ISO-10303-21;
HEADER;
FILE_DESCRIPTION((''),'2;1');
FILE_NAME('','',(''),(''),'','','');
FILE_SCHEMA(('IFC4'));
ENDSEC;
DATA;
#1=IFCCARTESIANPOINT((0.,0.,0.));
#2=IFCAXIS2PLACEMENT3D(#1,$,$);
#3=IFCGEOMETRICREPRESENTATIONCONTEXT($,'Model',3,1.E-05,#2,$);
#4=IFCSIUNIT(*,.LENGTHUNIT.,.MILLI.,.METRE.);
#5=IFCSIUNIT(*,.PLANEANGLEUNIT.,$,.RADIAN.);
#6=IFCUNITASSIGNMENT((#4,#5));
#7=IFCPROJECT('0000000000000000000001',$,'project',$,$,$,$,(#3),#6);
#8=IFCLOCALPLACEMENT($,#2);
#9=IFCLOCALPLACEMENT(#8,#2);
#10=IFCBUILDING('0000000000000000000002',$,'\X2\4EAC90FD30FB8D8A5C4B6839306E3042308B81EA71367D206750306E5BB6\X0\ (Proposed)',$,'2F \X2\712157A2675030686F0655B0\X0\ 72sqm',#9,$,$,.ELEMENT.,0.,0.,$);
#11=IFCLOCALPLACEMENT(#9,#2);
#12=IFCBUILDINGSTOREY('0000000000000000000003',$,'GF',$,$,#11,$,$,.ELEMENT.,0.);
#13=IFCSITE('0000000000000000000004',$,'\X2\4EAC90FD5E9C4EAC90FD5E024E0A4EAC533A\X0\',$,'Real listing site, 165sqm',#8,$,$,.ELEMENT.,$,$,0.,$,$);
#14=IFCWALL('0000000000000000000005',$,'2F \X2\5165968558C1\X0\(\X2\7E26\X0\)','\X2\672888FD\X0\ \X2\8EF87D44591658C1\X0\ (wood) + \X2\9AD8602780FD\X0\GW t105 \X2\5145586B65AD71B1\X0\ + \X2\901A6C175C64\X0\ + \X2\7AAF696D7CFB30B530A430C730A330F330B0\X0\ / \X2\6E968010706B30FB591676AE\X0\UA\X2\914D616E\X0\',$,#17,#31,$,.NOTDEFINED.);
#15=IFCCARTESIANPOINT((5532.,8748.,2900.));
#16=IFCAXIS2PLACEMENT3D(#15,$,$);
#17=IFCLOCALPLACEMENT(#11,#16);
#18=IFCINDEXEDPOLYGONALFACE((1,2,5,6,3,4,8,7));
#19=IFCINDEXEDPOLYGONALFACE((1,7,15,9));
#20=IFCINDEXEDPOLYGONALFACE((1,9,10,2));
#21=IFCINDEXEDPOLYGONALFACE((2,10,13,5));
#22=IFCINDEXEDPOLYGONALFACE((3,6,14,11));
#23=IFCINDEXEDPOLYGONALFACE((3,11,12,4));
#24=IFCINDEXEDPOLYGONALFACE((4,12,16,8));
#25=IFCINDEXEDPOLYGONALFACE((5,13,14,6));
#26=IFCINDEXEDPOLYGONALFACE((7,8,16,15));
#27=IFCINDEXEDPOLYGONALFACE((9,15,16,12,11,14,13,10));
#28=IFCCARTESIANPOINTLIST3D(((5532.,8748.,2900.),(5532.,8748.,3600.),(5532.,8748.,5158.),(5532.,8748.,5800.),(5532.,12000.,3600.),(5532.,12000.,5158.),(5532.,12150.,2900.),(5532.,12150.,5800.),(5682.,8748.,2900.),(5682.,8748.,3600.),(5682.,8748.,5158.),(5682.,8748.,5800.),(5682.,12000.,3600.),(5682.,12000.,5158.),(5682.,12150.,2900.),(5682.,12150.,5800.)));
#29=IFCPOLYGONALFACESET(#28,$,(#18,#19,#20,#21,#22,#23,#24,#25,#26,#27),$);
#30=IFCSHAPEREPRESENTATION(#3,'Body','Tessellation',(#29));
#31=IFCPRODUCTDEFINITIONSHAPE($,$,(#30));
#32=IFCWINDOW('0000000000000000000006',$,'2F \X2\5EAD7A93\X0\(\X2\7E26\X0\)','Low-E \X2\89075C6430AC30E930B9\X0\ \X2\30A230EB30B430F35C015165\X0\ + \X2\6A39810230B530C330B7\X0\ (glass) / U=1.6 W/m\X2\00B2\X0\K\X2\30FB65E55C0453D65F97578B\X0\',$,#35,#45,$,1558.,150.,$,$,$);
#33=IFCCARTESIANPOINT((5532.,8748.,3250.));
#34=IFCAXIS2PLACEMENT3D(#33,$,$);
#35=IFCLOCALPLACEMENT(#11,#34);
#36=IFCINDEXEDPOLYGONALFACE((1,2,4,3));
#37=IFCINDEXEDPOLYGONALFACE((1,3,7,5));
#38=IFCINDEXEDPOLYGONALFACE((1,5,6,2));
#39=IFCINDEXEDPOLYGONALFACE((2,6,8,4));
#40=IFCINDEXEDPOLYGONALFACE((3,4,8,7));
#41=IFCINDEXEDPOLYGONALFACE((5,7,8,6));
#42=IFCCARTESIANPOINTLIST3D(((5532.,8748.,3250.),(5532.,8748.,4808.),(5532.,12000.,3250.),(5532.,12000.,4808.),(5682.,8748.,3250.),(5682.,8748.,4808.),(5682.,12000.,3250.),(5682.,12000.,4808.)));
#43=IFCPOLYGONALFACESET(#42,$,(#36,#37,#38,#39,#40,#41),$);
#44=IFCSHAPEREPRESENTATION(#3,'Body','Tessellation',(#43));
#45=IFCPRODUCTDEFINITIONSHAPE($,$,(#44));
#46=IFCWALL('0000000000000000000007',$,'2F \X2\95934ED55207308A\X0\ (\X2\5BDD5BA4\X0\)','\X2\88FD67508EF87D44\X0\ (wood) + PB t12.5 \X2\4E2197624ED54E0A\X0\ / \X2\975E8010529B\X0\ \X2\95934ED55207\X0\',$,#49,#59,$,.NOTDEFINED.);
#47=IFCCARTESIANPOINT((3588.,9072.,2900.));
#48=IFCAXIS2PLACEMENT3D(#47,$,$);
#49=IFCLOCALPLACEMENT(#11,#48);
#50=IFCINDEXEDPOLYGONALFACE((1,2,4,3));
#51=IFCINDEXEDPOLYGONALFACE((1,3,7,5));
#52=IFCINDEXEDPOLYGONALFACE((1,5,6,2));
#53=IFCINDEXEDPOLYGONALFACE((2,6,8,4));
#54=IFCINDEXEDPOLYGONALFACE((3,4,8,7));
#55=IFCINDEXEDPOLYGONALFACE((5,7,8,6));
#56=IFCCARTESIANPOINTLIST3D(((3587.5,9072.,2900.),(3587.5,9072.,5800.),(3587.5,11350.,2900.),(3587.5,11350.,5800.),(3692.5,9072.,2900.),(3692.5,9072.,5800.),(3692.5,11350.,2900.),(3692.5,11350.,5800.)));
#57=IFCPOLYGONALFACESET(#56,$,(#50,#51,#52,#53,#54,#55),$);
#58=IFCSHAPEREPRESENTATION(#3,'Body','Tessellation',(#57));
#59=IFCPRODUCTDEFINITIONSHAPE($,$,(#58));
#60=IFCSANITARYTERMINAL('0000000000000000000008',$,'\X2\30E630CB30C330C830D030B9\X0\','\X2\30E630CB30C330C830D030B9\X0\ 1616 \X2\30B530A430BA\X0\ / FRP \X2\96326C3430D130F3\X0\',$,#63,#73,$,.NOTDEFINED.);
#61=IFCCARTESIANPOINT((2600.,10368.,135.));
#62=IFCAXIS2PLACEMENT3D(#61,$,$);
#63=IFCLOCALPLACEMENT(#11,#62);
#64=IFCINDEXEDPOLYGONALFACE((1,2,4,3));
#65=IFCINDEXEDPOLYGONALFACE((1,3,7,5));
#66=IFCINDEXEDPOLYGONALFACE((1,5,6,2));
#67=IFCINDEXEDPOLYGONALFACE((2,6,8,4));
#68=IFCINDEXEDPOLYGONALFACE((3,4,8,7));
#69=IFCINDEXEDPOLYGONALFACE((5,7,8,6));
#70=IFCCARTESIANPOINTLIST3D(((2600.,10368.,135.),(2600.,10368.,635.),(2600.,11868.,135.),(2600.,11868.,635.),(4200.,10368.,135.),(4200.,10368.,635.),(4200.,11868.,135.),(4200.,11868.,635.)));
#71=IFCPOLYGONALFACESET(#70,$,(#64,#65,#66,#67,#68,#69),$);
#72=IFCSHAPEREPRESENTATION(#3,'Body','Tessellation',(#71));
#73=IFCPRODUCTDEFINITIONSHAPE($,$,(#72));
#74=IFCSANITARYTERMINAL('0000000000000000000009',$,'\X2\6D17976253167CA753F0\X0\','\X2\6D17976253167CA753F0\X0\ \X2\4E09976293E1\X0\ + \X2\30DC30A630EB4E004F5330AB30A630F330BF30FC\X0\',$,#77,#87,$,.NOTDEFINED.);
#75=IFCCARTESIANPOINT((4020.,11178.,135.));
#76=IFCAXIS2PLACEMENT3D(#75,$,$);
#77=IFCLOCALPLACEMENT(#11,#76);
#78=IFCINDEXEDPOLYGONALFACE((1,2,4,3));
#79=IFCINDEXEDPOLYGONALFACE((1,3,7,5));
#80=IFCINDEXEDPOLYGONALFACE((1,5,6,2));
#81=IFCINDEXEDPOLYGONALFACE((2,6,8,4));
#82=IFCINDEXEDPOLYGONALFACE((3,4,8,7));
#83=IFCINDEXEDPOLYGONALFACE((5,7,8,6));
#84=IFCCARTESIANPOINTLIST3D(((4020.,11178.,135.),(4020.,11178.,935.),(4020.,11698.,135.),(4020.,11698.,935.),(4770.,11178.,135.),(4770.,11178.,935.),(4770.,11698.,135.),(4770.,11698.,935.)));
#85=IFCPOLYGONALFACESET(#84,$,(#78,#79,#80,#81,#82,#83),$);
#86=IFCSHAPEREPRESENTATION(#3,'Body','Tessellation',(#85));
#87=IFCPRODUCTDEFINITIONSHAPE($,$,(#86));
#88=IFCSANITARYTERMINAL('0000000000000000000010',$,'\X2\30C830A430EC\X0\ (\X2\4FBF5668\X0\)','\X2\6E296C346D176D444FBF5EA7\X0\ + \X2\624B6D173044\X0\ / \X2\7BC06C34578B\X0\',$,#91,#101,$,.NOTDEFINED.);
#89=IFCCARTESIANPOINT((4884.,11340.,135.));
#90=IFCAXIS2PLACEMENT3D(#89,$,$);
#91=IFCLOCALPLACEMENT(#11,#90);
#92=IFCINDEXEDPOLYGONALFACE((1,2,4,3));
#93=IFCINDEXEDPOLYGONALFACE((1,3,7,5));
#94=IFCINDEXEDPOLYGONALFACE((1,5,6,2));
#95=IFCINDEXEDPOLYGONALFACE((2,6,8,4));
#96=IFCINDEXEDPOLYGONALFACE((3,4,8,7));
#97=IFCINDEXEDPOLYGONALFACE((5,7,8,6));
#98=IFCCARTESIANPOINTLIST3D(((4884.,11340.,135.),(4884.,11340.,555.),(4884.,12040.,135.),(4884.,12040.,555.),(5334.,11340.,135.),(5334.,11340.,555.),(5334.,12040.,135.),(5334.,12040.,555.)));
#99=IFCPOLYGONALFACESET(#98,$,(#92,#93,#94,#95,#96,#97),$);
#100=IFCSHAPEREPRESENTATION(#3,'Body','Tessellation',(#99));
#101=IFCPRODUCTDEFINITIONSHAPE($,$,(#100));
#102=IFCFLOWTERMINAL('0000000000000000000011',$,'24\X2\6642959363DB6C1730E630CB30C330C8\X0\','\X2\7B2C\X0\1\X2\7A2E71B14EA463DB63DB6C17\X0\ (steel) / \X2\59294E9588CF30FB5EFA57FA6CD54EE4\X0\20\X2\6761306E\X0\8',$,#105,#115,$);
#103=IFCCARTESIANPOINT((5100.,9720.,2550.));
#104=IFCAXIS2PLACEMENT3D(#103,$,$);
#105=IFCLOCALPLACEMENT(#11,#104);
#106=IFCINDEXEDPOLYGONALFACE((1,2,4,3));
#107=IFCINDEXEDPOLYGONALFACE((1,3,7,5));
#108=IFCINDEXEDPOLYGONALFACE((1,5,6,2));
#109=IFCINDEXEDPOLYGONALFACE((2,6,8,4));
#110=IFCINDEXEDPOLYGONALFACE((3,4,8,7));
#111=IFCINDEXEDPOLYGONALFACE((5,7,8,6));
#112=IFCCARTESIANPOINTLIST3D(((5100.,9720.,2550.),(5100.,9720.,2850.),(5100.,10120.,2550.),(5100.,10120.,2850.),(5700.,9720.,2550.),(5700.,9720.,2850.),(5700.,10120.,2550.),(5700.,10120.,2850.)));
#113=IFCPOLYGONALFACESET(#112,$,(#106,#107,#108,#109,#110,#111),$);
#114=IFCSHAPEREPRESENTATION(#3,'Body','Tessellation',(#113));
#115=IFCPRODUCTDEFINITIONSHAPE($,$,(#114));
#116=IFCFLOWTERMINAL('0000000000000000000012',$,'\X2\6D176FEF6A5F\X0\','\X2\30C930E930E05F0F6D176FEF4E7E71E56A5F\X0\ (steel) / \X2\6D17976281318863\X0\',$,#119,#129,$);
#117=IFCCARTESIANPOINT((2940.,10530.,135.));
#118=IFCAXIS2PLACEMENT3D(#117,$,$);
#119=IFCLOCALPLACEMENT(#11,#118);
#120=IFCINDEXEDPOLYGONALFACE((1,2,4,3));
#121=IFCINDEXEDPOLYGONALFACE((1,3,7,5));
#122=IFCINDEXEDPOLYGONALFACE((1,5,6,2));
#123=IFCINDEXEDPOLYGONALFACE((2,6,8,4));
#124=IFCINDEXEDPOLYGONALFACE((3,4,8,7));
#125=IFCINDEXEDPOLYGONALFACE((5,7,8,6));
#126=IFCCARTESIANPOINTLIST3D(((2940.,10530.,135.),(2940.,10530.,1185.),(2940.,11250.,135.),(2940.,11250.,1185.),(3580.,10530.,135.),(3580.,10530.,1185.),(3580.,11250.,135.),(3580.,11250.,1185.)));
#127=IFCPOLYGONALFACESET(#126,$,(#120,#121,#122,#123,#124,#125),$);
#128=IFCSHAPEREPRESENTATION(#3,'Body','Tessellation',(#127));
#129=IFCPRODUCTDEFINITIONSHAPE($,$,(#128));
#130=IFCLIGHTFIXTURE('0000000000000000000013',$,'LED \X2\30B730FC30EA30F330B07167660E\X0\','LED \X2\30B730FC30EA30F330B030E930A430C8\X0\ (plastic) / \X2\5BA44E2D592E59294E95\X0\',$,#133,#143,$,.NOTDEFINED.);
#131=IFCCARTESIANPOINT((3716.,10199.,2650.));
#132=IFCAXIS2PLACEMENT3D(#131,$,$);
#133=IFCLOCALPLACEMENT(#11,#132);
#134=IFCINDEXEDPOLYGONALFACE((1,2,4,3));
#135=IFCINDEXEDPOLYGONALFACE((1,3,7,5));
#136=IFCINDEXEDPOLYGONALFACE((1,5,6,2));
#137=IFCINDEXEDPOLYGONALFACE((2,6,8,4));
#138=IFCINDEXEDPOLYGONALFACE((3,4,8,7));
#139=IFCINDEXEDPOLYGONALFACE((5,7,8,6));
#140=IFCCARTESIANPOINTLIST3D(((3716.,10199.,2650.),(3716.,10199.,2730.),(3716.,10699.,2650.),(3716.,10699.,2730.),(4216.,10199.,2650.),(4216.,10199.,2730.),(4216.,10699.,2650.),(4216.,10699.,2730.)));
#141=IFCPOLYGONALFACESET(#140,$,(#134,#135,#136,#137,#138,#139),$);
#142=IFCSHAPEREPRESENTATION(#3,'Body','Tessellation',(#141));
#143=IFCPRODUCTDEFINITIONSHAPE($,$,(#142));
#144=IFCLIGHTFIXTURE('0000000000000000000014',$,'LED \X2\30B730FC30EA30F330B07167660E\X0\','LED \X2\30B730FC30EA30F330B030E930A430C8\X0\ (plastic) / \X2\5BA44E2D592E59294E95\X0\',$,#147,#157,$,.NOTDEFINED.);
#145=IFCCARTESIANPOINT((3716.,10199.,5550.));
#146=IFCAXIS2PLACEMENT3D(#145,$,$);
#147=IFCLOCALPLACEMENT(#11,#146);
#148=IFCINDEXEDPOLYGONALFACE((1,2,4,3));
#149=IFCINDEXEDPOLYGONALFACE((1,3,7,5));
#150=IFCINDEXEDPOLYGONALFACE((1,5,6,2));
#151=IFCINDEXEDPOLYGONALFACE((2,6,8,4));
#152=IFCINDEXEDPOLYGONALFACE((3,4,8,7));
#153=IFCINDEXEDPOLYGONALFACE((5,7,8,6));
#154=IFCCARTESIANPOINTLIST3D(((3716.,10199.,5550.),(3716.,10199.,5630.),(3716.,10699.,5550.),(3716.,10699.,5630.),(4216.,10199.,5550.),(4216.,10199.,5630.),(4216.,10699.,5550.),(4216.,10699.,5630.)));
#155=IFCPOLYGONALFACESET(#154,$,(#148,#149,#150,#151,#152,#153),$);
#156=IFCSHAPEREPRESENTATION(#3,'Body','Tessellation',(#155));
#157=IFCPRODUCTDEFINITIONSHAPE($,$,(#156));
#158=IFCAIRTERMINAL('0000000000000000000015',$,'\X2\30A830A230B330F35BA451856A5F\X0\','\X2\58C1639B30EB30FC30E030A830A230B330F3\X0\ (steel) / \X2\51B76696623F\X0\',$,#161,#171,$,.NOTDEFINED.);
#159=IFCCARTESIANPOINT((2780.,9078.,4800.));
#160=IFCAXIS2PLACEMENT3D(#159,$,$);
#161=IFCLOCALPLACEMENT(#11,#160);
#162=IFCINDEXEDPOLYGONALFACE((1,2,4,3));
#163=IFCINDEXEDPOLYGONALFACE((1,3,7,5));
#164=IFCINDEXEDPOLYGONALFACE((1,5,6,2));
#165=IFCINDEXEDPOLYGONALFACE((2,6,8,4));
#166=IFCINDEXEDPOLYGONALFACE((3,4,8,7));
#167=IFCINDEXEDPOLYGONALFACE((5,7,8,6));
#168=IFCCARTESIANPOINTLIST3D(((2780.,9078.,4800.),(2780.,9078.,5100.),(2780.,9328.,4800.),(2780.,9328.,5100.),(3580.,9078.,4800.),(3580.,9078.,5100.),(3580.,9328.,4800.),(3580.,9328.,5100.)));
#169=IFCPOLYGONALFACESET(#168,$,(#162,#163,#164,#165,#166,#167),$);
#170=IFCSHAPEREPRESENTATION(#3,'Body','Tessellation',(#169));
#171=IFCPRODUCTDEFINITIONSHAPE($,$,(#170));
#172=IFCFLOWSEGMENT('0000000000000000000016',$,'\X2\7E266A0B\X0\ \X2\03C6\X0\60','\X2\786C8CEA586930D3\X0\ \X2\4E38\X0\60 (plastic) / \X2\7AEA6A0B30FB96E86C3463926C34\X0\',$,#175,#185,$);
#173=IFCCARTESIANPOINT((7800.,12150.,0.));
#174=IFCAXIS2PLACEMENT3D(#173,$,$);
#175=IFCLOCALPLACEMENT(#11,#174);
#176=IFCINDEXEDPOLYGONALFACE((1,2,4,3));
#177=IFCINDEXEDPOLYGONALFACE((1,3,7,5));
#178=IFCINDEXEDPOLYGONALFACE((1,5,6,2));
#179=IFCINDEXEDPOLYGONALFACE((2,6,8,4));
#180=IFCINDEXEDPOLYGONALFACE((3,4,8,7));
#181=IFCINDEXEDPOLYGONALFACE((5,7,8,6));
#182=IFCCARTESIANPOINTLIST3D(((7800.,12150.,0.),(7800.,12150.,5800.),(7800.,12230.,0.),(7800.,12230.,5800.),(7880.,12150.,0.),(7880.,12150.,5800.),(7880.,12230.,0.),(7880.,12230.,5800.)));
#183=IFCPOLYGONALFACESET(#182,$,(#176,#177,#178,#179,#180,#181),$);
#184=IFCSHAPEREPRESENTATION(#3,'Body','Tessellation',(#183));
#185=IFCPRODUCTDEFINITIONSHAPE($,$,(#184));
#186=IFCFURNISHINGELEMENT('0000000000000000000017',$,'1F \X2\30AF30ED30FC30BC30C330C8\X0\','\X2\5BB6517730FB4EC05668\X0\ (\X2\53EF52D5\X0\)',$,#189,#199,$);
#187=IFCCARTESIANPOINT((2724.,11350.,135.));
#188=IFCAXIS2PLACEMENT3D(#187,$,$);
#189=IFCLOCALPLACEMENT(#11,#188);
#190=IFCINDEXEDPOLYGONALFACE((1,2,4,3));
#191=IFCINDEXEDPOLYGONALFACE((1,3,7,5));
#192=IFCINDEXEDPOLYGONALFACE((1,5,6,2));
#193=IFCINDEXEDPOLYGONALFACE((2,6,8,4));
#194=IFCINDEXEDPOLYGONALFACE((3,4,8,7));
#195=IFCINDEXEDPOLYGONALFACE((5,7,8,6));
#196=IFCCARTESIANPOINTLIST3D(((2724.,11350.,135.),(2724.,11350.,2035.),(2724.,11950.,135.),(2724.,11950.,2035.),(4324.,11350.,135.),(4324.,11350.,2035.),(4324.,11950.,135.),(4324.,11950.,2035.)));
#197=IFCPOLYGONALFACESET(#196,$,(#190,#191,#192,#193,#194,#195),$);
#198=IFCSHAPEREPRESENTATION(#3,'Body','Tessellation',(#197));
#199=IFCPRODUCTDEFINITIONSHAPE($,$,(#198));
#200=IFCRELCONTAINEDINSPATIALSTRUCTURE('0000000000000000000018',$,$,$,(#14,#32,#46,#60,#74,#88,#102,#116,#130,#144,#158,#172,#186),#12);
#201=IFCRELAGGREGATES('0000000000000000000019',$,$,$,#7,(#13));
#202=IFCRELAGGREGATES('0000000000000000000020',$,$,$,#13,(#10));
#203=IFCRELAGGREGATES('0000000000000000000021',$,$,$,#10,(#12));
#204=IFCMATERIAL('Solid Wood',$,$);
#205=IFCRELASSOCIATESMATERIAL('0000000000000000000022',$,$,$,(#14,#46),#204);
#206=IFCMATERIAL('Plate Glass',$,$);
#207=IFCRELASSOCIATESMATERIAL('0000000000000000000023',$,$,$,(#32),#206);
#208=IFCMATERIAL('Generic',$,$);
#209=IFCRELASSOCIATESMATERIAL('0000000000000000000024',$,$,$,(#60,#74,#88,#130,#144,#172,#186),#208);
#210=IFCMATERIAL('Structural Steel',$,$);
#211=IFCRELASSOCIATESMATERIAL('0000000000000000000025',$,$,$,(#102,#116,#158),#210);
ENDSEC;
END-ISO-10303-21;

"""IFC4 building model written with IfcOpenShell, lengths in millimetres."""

from ifc_helpers import new_model, si_unit, frame, frame_2d, origin, place, context, project, spatial, rectangle, extrude, material, element, fill, save


model = new_model("IFC4")

# Units and contexts
model_context = context("Model", 3, precision=1e-05, world=origin())
ifc_project = project(units=[si_unit("LENGTHUNIT", "METRE", prefix="MILLI"), si_unit("PLANEANGLEUNIT", "RADIAN")], contexts=[model_context])

# Site, building, storey
site_placement = place(None, origin())
site = spatial("IfcSite", under=ifc_project, at=site_placement, Name="京都府京都市上京区", ObjectType="Real listing site, 165sqm", CompositionType="ELEMENT", RefElevation=0.0)
building_placement = place(site_placement, origin())
building = spatial("IfcBuilding", under=site, at=building_placement, Name="京都・越屋根のある自然素材の家 (Proposed)", ObjectType="2F 無垢材と漆喰 72sqm", CompositionType="ELEMENT", ElevationOfRefHeight=0.0, ElevationOfTerrain=0.0)
storey_placement = place(building_placement, origin())
storey = spatial("IfcBuildingStorey", under=building, at=storey_placement, Name="GF", CompositionType="ELEMENT", Elevation=0.0)

# Shared definitions
ifc_material_1 = material(Name="Solid Wood")

# Shared definitions
ifc_material_2 = material(Name="Plate Glass")

# Wall, opening, window
wall_1_placement = place(storey_placement, frame((5532.0, 8748.0, 2900.0)))
wall_1 = element("IfcWall", 1, at=wall_1_placement, inside=storey, material=ifc_material_1, Name="2F 入隅壁(縦)", Description="木製 軸組外壁 (wood) + 高性能GW t105 充填断熱 + 通気層 + 窯業系サイディング / 準耐火・外皮UA配慮", PredefinedType="NOTDEFINED", context=model_context, shape_type="SweptSolid", body=[
    extrude(rectangle(XDim=150.0, YDim=3402.0, at=frame_2d((75.0, 1701.0))), frame((5532.0, 8748.0, 2900.0)), (0.0, 0.0, 1.0), 2900.0),
])
opening_1_placement = place(storey_placement, frame((5532.0, 8748.0, 3250.0)))
opening_1 = element("IfcOpeningElement", 2, at=opening_1_placement, cuts=wall_1, PredefinedType="NOTDEFINED", context=model_context, shape_type="SweptSolid", body=[
    extrude(rectangle(XDim=150.0, YDim=3252.0, at=frame_2d((75.0, 1626.0))), frame((5532.0, 8748.0, 3250.0)), (0.0, 0.0, 1.0), 1558.0),
])
window_1_placement = place(storey_placement, frame((5532.0, 8748.0, 3250.0)))
window_1 = element("IfcWindow", 3, at=window_1_placement, inside=storey, material=ifc_material_2, Name="2F 庭窓(縦)", Description="Low-E 複層ガラス アルゴン封入 + 樹脂サッシ (glass) / U=1.6 W/m²K・日射取得型", OverallHeight=1558.0, OverallWidth=150.0, context=model_context, shape_type="SweptSolid", body=[
    extrude(rectangle(XDim=150.0, YDim=3252.0, at=frame_2d((75.0, 1626.0))), frame((5532.0, 8748.0, 3250.0)), (0.0, 0.0, 1.0), 1558.0),
])
fill(opening_1, window_1)

# Wall
wall_2_placement = place(storey_placement, frame((3588.0, 9072.0, 2900.0)))
element("IfcWall", 4, at=wall_2_placement, inside=storey, material=ifc_material_1, Name="2F 間仕切り (寝室)", Description="製材軸組 (wood) + PB t12.5 両面仕上 / 非耐力 間仕切", PredefinedType="NOTDEFINED", context=model_context, shape_type="SweptSolid", body=[
    extrude(rectangle(XDim=105.0, YDim=2278.0, at=frame_2d((52.0, 1139.0))), frame((3588.0, 9072.0, 2900.0)), (0.0, 0.0, 1.0), 2900.0),
])

# Sanitary terminals
ifc_material_3 = material(Name="Generic")
sanitary_terminal_1_placement = place(storey_placement, frame((2600.0, 10368.0, 135.0)))
element("IfcSanitaryTerminal", 5, at=sanitary_terminal_1_placement, inside=storey, material=ifc_material_3, Name="ユニットバス", Description="ユニットバス 1616 サイズ / FRP 防水パン", PredefinedType="NOTDEFINED", context=model_context, shape_type="SweptSolid", body=[
    extrude(rectangle(XDim=1600.0, YDim=1500.0, at=frame_2d((800.0, 750.0))), frame((2600.0, 10368.0, 135.0)), (0.0, 0.0, 1.0), 500.0),
])
sanitary_terminal_2_placement = place(storey_placement, frame((4020.0, 11178.0, 135.0)))
element("IfcSanitaryTerminal", 6, at=sanitary_terminal_2_placement, inside=storey, material=ifc_material_3, Name="洗面化粧台", Description="洗面化粧台 三面鏡 + ボウル一体カウンター", PredefinedType="NOTDEFINED", context=model_context, shape_type="SweptSolid", body=[
    extrude(rectangle(XDim=750.0, YDim=520.0, at=frame_2d((375.0, 260.0))), frame((4020.0, 11178.0, 135.0)), (0.0, 0.0, 1.0), 800.0),
])
sanitary_terminal_3_placement = place(storey_placement, frame((4884.0, 11340.0, 135.0)))
element("IfcSanitaryTerminal", 7, at=sanitary_terminal_3_placement, inside=storey, material=ifc_material_3, Name="トイレ (便器)", Description="温水洗浄便座 + 手洗い / 節水型", PredefinedType="NOTDEFINED", context=model_context, shape_type="SweptSolid", body=[
    extrude(rectangle(XDim=450.0, YDim=700.0, at=frame_2d((225.0, 350.0))), frame((4884.0, 11340.0, 135.0)), (0.0, 0.0, 1.0), 420.0),
])

# Flow terminals
ifc_material_4 = material(Name="Structural Steel")
flow_terminal_1_placement = place(storey_placement, frame((5100.0, 9720.0, 2550.0)))
element("IfcFlowTerminal", 8, at=flow_terminal_1_placement, inside=storey, material=ifc_material_4, Name="24時間換気ユニット", Description="第1種熱交換換気 (steel) / 天井裏・建基法令20条の8", context=model_context, shape_type="SweptSolid", body=[
    extrude(rectangle(XDim=600.0, YDim=400.0, at=frame_2d((300.0, 200.0))), frame((5100.0, 9720.0, 2550.0)), (0.0, 0.0, 1.0), 300.0),
])
flow_terminal_2_placement = place(storey_placement, frame((2940.0, 10530.0, 135.0)))
element("IfcFlowTerminal", 9, at=flow_terminal_2_placement, inside=storey, material=ifc_material_4, Name="洗濯機", Description="ドラム式洗濯乾燥機 (steel) / 洗面脱衣", context=model_context, shape_type="SweptSolid", body=[
    extrude(rectangle(XDim=640.0, YDim=720.0, at=frame_2d((320.0, 360.0))), frame((2940.0, 10530.0, 135.0)), (0.0, 0.0, 1.0), 1050.0),
])

# Light fixtures
light_fixture_1_placement = place(storey_placement, frame((3716.0, 10199.0, 2650.0)))
element("IfcLightFixture", 10, at=light_fixture_1_placement, inside=storey, material=ifc_material_3, Name="LED シーリング照明", Description="LED シーリングライト (plastic) / 室中央天井", PredefinedType="NOTDEFINED", context=model_context, shape_type="SweptSolid", body=[
    extrude(rectangle(XDim=500.0, YDim=500.0, at=frame_2d((250.0, 250.0))), frame((3716.0, 10199.0, 2650.0)), (0.0, 0.0, 1.0), 80.0),
])
light_fixture_2_placement = place(storey_placement, frame((3716.0, 10199.0, 5550.0)))
element("IfcLightFixture", 11, at=light_fixture_2_placement, inside=storey, material=ifc_material_3, Name="LED シーリング照明", Description="LED シーリングライト (plastic) / 室中央天井", PredefinedType="NOTDEFINED", context=model_context, shape_type="SweptSolid", body=[
    extrude(rectangle(XDim=500.0, YDim=500.0, at=frame_2d((250.0, 250.0))), frame((3716.0, 10199.0, 5550.0)), (0.0, 0.0, 1.0), 80.0),
])

# Air terminal
air_terminal_placement = place(storey_placement, frame((2780.0, 9078.0, 4800.0)))
element("IfcAirTerminal", 12, at=air_terminal_placement, inside=storey, material=ifc_material_4, Name="エアコン室内機", Description="壁掛ルームエアコン (steel) / 冷暖房", PredefinedType="NOTDEFINED", context=model_context, shape_type="SweptSolid", body=[
    extrude(rectangle(XDim=800.0, YDim=250.0, at=frame_2d((400.0, 125.0))), frame((2780.0, 9078.0, 4800.0)), (0.0, 0.0, 1.0), 300.0),
])

# Flow segment
flow_segment_placement = place(storey_placement, frame((7800.0, 12150.0, 0.0)))
element("IfcFlowSegment", 13, at=flow_segment_placement, inside=storey, material=ifc_material_3, Name="縦樋 φ60", Description="硬質塩ビ 丸60 (plastic) / 竪樋・雨水排水", context=model_context, shape_type="SweptSolid", body=[
    extrude(rectangle(XDim=80.0, YDim=80.0, at=frame_2d((40.0, 40.0))), frame((7800.0, 12150.0, 0.0)), (0.0, 0.0, 1.0), 5800.0),
])

# Furnishing element
furnishing_1_placement = place(storey_placement, frame((2724.0, 11350.0, 135.0)))
element("IfcFurnishingElement", 14, at=furnishing_1_placement, inside=storey, material=ifc_material_3, Name="1F クローゼット", Description="家具・什器 (可動)", context=model_context, shape_type="SweptSolid", body=[
    extrude(rectangle(XDim=1600.0, YDim=600.0, at=frame_2d((800.0, 300.0))), frame((2724.0, 11350.0, 135.0)), (0.0, 0.0, 1.0), 1900.0),
])

save(model, "model.ifc")
